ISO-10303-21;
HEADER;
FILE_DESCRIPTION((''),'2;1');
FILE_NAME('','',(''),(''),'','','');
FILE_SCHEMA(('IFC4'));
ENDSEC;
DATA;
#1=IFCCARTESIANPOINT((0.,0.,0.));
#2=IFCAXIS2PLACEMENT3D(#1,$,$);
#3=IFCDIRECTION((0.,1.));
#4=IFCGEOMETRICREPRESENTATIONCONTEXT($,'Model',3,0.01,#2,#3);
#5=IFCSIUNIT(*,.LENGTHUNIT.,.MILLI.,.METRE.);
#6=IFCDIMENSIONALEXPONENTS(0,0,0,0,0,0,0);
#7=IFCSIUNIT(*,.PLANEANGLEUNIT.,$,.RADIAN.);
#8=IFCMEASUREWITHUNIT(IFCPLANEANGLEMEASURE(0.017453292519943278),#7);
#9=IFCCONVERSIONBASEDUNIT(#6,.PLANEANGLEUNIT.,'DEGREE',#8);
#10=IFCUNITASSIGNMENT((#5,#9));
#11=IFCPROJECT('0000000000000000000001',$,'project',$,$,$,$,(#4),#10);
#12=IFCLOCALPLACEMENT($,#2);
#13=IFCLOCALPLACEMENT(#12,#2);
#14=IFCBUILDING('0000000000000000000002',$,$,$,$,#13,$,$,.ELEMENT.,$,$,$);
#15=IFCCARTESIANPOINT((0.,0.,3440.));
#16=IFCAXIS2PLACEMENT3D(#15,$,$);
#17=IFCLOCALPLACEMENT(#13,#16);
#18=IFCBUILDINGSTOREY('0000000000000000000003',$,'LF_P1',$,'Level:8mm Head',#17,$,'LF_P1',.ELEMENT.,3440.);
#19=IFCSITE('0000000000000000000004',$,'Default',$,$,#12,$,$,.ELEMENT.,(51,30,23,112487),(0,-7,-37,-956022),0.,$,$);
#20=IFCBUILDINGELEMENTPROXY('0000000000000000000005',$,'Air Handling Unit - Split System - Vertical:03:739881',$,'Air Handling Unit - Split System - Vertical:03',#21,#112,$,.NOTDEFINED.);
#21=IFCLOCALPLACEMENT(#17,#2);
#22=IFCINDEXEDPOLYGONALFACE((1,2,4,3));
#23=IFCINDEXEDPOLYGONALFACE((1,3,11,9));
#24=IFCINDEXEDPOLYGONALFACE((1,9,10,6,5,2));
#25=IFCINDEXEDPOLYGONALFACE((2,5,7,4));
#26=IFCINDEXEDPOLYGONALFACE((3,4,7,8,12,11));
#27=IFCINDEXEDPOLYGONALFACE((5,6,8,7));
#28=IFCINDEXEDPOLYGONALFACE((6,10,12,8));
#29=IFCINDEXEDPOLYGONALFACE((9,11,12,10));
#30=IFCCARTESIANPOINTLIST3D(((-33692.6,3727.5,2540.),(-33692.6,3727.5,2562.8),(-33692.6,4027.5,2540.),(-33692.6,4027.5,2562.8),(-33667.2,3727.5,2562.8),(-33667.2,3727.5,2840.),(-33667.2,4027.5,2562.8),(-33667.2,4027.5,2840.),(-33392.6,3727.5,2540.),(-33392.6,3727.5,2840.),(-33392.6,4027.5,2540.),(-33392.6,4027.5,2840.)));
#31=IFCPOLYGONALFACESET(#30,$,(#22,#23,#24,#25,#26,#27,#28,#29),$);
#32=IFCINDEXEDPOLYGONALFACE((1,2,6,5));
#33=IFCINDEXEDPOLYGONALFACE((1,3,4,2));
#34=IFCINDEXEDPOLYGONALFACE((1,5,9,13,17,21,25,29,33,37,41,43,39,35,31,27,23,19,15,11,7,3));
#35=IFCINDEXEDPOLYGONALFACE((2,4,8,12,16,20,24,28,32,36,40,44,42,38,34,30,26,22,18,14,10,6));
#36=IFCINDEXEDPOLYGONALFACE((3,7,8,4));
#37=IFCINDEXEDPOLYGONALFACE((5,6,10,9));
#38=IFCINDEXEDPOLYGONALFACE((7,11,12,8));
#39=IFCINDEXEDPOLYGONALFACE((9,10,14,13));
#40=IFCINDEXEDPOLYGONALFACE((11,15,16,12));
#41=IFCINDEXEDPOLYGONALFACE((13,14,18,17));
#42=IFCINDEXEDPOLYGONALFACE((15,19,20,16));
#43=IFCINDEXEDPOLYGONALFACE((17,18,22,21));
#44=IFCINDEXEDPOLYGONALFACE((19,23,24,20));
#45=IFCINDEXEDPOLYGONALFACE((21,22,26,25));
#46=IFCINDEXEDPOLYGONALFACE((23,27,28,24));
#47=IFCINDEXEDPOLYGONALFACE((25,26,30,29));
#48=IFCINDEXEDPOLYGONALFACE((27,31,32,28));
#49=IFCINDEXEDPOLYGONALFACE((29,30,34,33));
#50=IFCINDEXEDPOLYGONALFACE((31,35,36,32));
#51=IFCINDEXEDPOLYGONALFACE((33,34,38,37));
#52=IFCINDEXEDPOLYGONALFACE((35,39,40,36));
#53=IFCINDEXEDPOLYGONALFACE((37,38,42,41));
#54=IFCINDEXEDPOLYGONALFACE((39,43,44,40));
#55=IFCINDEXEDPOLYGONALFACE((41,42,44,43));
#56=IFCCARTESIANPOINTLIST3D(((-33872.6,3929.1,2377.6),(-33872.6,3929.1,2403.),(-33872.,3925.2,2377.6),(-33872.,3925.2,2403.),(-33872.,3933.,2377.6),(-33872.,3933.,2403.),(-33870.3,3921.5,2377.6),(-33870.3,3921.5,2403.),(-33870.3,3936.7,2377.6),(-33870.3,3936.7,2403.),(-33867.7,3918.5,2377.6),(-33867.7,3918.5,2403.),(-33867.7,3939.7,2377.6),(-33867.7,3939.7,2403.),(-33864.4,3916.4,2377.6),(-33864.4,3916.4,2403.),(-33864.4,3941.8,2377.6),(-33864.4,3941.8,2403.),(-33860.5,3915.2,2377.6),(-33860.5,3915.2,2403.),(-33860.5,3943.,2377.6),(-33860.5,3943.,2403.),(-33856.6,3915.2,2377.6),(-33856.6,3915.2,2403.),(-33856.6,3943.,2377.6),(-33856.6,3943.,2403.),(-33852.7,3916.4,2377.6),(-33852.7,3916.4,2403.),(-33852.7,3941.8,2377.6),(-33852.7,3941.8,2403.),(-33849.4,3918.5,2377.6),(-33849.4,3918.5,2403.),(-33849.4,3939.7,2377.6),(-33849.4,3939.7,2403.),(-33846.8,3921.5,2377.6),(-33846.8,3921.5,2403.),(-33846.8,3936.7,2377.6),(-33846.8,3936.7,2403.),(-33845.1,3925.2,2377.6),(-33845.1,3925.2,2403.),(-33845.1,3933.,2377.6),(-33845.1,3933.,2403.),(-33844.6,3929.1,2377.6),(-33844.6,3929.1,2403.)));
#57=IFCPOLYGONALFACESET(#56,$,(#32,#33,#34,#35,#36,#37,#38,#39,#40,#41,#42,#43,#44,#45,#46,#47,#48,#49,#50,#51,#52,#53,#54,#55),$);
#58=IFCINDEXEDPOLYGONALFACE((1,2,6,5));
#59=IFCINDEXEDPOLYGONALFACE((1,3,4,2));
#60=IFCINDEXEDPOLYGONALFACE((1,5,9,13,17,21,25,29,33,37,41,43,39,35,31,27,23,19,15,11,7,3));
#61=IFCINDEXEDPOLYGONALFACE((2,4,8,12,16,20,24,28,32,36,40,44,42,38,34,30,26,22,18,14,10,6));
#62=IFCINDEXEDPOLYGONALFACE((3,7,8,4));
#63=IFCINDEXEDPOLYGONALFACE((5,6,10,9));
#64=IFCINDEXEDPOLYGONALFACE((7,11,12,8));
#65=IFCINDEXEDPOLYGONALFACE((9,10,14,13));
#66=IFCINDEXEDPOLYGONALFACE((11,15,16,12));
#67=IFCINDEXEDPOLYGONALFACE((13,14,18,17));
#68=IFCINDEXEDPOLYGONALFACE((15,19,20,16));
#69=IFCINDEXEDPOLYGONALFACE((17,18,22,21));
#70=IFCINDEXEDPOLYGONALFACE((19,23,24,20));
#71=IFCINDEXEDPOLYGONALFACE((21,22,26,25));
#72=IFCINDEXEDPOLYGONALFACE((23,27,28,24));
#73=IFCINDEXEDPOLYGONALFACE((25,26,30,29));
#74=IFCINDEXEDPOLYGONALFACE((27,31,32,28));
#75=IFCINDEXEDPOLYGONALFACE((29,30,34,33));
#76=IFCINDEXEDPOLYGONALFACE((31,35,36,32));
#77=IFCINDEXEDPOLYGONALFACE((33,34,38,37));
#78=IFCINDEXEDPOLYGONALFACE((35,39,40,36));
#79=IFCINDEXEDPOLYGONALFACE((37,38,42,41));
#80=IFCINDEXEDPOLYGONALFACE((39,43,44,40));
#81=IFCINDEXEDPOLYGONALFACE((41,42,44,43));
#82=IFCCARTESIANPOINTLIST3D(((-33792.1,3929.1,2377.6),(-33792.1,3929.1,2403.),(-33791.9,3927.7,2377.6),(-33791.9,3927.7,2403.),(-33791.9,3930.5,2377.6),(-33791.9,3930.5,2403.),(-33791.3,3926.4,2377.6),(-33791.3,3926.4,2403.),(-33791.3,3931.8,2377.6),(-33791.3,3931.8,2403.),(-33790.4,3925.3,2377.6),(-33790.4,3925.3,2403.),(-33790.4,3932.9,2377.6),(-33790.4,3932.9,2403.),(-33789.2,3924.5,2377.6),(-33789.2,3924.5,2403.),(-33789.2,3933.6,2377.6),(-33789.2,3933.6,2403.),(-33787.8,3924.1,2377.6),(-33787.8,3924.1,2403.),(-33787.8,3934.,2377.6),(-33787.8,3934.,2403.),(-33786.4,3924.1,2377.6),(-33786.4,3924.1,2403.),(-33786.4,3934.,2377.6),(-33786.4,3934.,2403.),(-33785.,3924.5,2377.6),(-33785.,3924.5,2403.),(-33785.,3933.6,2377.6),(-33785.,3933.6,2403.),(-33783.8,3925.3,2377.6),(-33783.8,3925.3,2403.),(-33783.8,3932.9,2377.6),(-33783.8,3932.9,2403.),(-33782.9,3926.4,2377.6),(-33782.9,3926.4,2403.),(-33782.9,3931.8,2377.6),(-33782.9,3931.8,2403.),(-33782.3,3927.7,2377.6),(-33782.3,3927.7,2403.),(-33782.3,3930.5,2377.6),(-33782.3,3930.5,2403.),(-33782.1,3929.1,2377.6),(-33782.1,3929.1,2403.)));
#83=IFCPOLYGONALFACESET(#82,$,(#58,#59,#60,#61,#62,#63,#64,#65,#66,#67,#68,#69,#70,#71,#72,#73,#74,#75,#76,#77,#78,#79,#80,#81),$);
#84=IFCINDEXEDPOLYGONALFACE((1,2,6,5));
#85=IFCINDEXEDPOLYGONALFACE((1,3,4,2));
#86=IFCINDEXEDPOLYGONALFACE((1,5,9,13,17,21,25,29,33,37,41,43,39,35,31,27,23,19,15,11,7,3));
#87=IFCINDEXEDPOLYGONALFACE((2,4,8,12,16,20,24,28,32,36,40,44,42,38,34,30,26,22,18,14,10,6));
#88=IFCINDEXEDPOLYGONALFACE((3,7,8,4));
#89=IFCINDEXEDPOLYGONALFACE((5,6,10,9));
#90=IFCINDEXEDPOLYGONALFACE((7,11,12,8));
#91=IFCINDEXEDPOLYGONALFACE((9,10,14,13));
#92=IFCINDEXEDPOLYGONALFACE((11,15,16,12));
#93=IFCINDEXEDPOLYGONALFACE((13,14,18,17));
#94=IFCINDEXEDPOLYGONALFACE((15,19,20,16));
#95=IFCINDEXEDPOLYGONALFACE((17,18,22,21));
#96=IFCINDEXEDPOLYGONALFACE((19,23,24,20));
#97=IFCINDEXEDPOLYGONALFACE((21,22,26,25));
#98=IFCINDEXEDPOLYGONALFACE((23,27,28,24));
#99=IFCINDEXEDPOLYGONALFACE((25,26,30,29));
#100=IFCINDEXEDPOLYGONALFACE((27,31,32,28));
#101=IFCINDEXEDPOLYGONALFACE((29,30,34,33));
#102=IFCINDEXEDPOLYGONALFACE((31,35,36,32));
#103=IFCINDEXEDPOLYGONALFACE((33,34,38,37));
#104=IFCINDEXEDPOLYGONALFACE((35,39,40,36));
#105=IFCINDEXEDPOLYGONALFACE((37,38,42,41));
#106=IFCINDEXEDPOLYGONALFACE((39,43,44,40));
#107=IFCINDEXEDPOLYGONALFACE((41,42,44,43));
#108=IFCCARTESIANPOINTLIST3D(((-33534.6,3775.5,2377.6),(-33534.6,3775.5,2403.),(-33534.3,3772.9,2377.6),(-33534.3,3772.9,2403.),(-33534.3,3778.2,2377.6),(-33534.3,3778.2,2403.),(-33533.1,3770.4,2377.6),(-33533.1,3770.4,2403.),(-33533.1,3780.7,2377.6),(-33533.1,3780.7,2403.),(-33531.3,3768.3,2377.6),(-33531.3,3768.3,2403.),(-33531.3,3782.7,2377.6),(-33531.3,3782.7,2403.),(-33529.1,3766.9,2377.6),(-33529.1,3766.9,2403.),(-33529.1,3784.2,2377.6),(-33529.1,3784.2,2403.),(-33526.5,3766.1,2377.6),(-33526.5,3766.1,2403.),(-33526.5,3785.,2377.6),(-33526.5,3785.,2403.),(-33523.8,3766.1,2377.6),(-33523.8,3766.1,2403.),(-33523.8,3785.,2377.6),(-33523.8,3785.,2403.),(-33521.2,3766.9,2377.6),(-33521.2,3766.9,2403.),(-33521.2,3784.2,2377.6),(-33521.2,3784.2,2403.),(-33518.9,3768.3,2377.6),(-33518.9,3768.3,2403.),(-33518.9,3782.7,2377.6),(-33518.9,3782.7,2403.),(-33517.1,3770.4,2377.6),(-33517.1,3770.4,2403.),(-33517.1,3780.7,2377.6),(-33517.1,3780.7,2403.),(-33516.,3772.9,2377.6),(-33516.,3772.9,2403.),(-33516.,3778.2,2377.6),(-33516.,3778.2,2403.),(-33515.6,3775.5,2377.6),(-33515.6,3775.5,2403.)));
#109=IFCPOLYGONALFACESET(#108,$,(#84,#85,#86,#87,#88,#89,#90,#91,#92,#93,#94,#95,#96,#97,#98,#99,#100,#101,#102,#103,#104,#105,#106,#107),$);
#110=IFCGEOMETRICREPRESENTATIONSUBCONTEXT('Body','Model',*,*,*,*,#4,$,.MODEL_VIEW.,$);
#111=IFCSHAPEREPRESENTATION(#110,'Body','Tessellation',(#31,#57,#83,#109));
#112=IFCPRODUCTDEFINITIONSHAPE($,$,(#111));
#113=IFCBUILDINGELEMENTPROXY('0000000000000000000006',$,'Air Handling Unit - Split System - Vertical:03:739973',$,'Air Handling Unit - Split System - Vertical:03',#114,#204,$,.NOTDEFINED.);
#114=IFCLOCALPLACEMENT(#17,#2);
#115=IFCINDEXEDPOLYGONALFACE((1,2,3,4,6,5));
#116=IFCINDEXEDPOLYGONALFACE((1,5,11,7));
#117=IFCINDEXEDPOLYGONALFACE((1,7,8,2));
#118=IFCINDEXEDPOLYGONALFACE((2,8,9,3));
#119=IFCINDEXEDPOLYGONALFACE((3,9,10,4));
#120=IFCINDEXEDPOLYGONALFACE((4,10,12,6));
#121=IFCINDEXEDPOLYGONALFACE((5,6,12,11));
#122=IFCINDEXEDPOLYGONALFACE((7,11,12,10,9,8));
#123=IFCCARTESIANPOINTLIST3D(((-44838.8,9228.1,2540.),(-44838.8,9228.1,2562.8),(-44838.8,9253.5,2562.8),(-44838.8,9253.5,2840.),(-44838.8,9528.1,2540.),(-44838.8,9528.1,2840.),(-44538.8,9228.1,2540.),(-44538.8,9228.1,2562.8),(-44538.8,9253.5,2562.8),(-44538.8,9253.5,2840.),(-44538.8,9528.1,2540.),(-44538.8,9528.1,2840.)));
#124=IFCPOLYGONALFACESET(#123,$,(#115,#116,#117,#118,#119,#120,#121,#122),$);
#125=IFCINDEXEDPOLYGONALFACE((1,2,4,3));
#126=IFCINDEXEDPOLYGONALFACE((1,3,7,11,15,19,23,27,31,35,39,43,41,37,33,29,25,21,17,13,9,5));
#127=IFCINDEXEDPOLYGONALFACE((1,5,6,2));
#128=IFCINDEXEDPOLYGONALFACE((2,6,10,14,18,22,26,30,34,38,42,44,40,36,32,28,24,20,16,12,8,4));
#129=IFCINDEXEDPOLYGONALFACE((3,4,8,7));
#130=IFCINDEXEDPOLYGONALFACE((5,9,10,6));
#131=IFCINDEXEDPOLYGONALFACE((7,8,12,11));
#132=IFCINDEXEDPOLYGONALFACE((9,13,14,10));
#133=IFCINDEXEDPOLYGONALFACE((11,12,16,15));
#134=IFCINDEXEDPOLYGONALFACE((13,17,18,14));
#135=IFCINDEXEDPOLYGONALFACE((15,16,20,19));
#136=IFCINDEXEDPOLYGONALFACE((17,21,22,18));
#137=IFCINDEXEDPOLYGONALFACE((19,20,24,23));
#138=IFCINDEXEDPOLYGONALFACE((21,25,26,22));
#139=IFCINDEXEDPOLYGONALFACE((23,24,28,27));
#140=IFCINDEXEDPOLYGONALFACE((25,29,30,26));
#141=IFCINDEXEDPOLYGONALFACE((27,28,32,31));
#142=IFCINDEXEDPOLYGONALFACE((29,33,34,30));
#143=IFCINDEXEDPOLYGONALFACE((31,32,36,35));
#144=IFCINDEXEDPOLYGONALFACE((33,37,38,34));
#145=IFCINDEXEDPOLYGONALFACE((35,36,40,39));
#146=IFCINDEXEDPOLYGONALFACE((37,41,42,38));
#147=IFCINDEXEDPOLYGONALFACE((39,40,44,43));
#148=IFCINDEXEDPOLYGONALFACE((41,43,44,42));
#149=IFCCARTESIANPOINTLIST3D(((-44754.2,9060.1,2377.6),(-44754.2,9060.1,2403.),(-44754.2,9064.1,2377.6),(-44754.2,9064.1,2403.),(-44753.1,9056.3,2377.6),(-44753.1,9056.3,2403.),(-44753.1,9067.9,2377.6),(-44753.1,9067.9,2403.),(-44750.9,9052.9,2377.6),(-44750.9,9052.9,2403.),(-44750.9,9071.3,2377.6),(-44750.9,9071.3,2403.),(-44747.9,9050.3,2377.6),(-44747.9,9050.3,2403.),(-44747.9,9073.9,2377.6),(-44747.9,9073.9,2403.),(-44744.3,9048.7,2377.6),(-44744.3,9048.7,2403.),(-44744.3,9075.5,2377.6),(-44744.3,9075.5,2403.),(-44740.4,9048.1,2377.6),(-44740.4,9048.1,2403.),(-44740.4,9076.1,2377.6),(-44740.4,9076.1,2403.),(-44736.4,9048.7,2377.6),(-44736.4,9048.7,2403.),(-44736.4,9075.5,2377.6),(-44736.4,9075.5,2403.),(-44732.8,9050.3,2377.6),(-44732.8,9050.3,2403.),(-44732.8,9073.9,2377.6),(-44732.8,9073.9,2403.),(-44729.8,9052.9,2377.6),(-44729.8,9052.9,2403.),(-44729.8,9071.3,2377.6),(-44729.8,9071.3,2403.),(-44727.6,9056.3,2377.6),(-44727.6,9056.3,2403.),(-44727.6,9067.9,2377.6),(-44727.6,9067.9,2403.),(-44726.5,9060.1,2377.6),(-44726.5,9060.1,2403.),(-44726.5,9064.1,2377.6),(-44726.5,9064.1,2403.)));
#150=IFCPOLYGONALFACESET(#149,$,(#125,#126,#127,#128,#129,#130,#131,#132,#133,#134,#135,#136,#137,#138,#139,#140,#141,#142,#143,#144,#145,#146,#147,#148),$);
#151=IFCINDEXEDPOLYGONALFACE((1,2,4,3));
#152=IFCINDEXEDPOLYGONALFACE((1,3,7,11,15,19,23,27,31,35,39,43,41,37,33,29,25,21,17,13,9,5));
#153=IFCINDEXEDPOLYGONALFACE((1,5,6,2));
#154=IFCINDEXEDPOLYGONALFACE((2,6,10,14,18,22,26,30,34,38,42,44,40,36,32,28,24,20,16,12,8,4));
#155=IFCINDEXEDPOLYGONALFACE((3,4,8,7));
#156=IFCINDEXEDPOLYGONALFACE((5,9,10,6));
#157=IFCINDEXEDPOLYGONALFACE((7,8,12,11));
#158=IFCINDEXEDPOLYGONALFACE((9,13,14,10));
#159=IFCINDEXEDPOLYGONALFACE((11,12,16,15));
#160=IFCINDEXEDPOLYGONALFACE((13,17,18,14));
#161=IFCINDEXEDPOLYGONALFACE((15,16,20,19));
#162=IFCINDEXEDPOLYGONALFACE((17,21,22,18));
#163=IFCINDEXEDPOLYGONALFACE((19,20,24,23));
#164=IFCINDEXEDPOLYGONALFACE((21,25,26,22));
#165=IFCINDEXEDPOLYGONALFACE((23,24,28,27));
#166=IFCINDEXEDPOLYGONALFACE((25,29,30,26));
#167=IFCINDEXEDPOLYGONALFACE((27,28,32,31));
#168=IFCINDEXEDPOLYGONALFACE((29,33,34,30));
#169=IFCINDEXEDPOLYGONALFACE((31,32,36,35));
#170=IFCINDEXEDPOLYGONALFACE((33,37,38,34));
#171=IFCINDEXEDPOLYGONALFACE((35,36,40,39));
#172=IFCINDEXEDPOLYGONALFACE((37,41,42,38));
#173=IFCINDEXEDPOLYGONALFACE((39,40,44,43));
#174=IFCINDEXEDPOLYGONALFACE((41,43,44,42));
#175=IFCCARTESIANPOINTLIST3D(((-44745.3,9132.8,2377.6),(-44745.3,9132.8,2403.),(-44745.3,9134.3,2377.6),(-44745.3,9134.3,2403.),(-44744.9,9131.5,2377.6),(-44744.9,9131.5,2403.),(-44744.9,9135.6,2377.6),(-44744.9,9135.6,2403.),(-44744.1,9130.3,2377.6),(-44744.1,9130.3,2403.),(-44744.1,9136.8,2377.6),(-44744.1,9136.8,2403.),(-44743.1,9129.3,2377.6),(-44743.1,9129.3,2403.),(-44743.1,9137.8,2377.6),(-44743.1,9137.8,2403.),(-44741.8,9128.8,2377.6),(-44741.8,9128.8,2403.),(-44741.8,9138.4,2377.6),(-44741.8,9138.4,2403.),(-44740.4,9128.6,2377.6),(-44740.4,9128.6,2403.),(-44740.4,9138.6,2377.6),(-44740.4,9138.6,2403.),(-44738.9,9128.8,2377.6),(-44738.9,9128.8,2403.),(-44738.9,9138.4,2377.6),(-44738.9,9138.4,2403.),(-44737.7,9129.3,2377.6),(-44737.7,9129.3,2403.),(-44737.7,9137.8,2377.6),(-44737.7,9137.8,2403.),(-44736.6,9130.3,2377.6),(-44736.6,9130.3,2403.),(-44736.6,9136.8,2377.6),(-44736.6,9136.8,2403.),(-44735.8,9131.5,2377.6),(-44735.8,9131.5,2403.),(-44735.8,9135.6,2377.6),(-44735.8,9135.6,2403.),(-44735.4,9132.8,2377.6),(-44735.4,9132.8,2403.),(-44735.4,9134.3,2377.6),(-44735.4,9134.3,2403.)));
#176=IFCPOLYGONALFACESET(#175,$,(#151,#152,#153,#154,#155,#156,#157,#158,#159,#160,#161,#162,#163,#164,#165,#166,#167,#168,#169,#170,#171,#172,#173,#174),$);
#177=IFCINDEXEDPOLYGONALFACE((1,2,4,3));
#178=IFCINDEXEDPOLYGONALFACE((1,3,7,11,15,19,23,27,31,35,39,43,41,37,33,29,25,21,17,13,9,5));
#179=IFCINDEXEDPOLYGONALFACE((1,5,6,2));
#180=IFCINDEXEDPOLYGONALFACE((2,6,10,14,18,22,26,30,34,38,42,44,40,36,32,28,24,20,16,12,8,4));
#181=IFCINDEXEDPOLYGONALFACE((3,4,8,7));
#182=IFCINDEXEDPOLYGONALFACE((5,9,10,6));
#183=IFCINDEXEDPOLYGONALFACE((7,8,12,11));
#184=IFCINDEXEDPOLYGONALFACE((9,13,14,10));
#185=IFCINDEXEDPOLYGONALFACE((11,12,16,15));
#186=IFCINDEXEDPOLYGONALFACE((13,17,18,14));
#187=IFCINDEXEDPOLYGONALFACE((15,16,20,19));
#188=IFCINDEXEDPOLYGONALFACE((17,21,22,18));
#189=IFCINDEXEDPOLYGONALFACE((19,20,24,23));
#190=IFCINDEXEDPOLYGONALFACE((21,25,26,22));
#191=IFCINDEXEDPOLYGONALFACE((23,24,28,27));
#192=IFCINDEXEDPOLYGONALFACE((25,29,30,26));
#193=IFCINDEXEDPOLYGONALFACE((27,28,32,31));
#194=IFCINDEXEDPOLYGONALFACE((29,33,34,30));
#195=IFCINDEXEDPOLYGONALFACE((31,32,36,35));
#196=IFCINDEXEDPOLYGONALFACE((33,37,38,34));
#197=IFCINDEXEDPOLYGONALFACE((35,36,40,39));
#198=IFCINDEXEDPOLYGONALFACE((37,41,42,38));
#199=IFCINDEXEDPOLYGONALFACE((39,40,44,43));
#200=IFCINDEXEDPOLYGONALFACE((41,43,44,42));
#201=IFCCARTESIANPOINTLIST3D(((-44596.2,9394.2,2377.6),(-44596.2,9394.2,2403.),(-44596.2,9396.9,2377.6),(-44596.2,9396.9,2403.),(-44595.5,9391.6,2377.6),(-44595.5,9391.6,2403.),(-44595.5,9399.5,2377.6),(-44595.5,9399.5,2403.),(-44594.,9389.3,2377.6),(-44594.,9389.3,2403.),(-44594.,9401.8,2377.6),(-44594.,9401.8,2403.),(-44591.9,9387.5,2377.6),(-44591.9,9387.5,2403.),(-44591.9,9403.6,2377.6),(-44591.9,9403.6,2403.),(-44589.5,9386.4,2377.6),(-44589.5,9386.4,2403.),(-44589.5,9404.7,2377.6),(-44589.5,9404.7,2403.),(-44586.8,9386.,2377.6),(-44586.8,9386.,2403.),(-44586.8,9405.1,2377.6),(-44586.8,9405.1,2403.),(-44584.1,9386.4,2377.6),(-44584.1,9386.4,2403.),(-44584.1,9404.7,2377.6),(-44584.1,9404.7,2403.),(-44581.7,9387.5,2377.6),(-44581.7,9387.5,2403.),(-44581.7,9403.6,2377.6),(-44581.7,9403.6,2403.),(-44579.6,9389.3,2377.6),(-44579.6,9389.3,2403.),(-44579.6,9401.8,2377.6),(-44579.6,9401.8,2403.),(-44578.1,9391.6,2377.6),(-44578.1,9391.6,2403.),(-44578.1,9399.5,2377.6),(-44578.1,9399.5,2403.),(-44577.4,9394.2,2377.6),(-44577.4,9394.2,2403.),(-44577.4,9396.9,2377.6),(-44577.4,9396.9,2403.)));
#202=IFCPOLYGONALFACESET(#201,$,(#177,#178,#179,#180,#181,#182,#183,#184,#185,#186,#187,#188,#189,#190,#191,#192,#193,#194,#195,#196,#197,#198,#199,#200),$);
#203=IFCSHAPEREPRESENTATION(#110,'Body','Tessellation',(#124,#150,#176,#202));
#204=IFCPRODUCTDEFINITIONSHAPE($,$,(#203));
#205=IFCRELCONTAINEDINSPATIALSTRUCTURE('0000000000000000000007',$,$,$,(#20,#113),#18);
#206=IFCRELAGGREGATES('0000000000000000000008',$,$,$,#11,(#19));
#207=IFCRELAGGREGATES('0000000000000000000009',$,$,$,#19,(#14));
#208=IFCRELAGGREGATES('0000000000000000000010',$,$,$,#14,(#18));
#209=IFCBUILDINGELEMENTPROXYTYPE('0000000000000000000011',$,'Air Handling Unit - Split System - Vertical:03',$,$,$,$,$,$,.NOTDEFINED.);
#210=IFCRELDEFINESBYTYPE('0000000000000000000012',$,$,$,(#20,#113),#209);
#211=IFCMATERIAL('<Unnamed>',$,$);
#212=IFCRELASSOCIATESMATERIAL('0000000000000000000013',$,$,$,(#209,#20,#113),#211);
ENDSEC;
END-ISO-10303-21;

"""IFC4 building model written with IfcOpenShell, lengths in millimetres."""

from ifc_helpers import new_model, entity, si_unit, converted_unit, direction, frame, origin, place, context, subcontext, project, spatial, arc, indexed_curve, outline, extrude, source, transform, mapped, material, type_object, type_shapes, element, save


model = new_model("IFC4")

# Units and contexts
model_context = context("Model", 3, precision=0.01, world=origin(), true_north=direction((0.0, 1.0)))
body_context = subcontext(model_context, "Body", "Model", "MODEL_VIEW")
ifc_project = project(units=[si_unit("LENGTHUNIT", "METRE", prefix="MILLI"), converted_unit("PLANEANGLEUNIT", "DEGREE", entity("IfcPlaneAngleMeasure", 0.017453292519943278), si_unit("PLANEANGLEUNIT", "RADIAN"), dimensions=[0, 0, 0, 0, 0, 0, 0])], contexts=[model_context])

# Site, building, storey
site_placement = place(None, origin())
site = spatial("IfcSite", under=ifc_project, at=site_placement, Name="Default", CompositionType="ELEMENT", RefLatitude=(51, 30, 23, 112487), RefLongitude=(0, -7, -37, -956022), RefElevation=0.0)
building_placement = place(site_placement, origin())
building = spatial("IfcBuilding", under=site, at=building_placement, CompositionType="ELEMENT")
storey_placement = place(building_placement, frame((0.0, 0.0, 3440.0)))
storey = spatial("IfcBuildingStorey", under=building, at=storey_placement, Name="LF_P1", ObjectType="Level:8mm Head", LongName="LF_P1", CompositionType="ELEMENT", Elevation=3440.0)

# Shared definitions
ifc_material = material(Name="<Unnamed>")

# Building element proxies
building_element_proxy_type_1 = type_object("IfcBuildingElementProxyType", Name="Air Handling Unit - Split System - Vertical:03", PredefinedType="NOTDEFINED", material=ifc_material)
shared_shape_1 = source(origin(), body_context, "Body", "SweptSolid", [
    extrude(outline(indexed_curve([(-191.5, -107.6), (108.5, -107.6), (108.5, -84.8), (83.1, -84.8), (83.1, 192.4), (-191.5, 192.4), (-191.5, -107.6)], self_intersect=False)), frame((-150.0, 42.4, 191.5), z_axis=(1.0, 0.0, 0.0), x_axis=(0.0, 0.0, 1.0)), (0.0, 0.0, 1.0), 300.0),
    extrude(outline(indexed_curve([(-14.0, 0.0), (0.0, -14.0), (14.0, 0.0), (0.0, 14.0)], segments=[arc(1, 2, 3), arc(3, 4, 1)], self_intersect=False)), frame((51.6, 287.0, 466.0), z_axis=(0.0, 1.0, 0.0), x_axis=(0.0, 0.0, -1.0)), (0.0, 0.0, 1.0), 25.4),
    extrude(outline(indexed_curve([(-5.0, 0.0), (0.0, -5.0), (5.0, 0.0), (0.0, 5.0)], segments=[arc(1, 2, 3), arc(3, 4, 1)], self_intersect=False)), frame((51.6, 287.0, 394.6), z_axis=(0.0, 1.0, 0.0), x_axis=(0.0, 0.0, -1.0)), (0.0, 0.0, 1.0), 25.4),
    extrude(outline(indexed_curve([(-9.5, 0.0), (0.0, -9.5), (9.5, 0.0), (0.0, 9.5)], segments=[arc(1, 2, 3), arc(3, 4, 1)], self_intersect=False)), frame((-102.0, 287.0, 132.6), z_axis=(0.0, 1.0, 0.0), x_axis=(0.0, 0.0, -1.0)), (0.0, 0.0, 1.0), 25.4),
])
type_shapes(building_element_proxy_type_1, [shared_shape_1])
for number, where, z_axis, x_axis, name in (
    (1, (-33392.6, 3877.5, 2690.0), (-1.0, 0.0, 0.0), (0.0, 1.0, 0.0), "Air Handling Unit - Split System - Vertical:03:739881"),
    (2, (-44688.8, 9528.1, 2690.0), (0.0, -1.0, 0.0), (-1.0, 0.0, 0.0), "Air Handling Unit - Split System - Vertical:03:739973"),
):
    element("IfcBuildingElementProxy", number, at=place(storey_placement, frame(where, z_axis=z_axis, x_axis=x_axis)), inside=storey, type_object=building_element_proxy_type_1, material=ifc_material, Name=name, ObjectType="Air Handling Unit - Split System - Vertical:03", PredefinedType="NOTDEFINED", context=body_context, shape_type="MappedRepresentation", body=[
        mapped(shared_shape_1, transform((0.0, 0.0, 0.0), scale=1.0)),
    ])

save(model, "model.ifc")
